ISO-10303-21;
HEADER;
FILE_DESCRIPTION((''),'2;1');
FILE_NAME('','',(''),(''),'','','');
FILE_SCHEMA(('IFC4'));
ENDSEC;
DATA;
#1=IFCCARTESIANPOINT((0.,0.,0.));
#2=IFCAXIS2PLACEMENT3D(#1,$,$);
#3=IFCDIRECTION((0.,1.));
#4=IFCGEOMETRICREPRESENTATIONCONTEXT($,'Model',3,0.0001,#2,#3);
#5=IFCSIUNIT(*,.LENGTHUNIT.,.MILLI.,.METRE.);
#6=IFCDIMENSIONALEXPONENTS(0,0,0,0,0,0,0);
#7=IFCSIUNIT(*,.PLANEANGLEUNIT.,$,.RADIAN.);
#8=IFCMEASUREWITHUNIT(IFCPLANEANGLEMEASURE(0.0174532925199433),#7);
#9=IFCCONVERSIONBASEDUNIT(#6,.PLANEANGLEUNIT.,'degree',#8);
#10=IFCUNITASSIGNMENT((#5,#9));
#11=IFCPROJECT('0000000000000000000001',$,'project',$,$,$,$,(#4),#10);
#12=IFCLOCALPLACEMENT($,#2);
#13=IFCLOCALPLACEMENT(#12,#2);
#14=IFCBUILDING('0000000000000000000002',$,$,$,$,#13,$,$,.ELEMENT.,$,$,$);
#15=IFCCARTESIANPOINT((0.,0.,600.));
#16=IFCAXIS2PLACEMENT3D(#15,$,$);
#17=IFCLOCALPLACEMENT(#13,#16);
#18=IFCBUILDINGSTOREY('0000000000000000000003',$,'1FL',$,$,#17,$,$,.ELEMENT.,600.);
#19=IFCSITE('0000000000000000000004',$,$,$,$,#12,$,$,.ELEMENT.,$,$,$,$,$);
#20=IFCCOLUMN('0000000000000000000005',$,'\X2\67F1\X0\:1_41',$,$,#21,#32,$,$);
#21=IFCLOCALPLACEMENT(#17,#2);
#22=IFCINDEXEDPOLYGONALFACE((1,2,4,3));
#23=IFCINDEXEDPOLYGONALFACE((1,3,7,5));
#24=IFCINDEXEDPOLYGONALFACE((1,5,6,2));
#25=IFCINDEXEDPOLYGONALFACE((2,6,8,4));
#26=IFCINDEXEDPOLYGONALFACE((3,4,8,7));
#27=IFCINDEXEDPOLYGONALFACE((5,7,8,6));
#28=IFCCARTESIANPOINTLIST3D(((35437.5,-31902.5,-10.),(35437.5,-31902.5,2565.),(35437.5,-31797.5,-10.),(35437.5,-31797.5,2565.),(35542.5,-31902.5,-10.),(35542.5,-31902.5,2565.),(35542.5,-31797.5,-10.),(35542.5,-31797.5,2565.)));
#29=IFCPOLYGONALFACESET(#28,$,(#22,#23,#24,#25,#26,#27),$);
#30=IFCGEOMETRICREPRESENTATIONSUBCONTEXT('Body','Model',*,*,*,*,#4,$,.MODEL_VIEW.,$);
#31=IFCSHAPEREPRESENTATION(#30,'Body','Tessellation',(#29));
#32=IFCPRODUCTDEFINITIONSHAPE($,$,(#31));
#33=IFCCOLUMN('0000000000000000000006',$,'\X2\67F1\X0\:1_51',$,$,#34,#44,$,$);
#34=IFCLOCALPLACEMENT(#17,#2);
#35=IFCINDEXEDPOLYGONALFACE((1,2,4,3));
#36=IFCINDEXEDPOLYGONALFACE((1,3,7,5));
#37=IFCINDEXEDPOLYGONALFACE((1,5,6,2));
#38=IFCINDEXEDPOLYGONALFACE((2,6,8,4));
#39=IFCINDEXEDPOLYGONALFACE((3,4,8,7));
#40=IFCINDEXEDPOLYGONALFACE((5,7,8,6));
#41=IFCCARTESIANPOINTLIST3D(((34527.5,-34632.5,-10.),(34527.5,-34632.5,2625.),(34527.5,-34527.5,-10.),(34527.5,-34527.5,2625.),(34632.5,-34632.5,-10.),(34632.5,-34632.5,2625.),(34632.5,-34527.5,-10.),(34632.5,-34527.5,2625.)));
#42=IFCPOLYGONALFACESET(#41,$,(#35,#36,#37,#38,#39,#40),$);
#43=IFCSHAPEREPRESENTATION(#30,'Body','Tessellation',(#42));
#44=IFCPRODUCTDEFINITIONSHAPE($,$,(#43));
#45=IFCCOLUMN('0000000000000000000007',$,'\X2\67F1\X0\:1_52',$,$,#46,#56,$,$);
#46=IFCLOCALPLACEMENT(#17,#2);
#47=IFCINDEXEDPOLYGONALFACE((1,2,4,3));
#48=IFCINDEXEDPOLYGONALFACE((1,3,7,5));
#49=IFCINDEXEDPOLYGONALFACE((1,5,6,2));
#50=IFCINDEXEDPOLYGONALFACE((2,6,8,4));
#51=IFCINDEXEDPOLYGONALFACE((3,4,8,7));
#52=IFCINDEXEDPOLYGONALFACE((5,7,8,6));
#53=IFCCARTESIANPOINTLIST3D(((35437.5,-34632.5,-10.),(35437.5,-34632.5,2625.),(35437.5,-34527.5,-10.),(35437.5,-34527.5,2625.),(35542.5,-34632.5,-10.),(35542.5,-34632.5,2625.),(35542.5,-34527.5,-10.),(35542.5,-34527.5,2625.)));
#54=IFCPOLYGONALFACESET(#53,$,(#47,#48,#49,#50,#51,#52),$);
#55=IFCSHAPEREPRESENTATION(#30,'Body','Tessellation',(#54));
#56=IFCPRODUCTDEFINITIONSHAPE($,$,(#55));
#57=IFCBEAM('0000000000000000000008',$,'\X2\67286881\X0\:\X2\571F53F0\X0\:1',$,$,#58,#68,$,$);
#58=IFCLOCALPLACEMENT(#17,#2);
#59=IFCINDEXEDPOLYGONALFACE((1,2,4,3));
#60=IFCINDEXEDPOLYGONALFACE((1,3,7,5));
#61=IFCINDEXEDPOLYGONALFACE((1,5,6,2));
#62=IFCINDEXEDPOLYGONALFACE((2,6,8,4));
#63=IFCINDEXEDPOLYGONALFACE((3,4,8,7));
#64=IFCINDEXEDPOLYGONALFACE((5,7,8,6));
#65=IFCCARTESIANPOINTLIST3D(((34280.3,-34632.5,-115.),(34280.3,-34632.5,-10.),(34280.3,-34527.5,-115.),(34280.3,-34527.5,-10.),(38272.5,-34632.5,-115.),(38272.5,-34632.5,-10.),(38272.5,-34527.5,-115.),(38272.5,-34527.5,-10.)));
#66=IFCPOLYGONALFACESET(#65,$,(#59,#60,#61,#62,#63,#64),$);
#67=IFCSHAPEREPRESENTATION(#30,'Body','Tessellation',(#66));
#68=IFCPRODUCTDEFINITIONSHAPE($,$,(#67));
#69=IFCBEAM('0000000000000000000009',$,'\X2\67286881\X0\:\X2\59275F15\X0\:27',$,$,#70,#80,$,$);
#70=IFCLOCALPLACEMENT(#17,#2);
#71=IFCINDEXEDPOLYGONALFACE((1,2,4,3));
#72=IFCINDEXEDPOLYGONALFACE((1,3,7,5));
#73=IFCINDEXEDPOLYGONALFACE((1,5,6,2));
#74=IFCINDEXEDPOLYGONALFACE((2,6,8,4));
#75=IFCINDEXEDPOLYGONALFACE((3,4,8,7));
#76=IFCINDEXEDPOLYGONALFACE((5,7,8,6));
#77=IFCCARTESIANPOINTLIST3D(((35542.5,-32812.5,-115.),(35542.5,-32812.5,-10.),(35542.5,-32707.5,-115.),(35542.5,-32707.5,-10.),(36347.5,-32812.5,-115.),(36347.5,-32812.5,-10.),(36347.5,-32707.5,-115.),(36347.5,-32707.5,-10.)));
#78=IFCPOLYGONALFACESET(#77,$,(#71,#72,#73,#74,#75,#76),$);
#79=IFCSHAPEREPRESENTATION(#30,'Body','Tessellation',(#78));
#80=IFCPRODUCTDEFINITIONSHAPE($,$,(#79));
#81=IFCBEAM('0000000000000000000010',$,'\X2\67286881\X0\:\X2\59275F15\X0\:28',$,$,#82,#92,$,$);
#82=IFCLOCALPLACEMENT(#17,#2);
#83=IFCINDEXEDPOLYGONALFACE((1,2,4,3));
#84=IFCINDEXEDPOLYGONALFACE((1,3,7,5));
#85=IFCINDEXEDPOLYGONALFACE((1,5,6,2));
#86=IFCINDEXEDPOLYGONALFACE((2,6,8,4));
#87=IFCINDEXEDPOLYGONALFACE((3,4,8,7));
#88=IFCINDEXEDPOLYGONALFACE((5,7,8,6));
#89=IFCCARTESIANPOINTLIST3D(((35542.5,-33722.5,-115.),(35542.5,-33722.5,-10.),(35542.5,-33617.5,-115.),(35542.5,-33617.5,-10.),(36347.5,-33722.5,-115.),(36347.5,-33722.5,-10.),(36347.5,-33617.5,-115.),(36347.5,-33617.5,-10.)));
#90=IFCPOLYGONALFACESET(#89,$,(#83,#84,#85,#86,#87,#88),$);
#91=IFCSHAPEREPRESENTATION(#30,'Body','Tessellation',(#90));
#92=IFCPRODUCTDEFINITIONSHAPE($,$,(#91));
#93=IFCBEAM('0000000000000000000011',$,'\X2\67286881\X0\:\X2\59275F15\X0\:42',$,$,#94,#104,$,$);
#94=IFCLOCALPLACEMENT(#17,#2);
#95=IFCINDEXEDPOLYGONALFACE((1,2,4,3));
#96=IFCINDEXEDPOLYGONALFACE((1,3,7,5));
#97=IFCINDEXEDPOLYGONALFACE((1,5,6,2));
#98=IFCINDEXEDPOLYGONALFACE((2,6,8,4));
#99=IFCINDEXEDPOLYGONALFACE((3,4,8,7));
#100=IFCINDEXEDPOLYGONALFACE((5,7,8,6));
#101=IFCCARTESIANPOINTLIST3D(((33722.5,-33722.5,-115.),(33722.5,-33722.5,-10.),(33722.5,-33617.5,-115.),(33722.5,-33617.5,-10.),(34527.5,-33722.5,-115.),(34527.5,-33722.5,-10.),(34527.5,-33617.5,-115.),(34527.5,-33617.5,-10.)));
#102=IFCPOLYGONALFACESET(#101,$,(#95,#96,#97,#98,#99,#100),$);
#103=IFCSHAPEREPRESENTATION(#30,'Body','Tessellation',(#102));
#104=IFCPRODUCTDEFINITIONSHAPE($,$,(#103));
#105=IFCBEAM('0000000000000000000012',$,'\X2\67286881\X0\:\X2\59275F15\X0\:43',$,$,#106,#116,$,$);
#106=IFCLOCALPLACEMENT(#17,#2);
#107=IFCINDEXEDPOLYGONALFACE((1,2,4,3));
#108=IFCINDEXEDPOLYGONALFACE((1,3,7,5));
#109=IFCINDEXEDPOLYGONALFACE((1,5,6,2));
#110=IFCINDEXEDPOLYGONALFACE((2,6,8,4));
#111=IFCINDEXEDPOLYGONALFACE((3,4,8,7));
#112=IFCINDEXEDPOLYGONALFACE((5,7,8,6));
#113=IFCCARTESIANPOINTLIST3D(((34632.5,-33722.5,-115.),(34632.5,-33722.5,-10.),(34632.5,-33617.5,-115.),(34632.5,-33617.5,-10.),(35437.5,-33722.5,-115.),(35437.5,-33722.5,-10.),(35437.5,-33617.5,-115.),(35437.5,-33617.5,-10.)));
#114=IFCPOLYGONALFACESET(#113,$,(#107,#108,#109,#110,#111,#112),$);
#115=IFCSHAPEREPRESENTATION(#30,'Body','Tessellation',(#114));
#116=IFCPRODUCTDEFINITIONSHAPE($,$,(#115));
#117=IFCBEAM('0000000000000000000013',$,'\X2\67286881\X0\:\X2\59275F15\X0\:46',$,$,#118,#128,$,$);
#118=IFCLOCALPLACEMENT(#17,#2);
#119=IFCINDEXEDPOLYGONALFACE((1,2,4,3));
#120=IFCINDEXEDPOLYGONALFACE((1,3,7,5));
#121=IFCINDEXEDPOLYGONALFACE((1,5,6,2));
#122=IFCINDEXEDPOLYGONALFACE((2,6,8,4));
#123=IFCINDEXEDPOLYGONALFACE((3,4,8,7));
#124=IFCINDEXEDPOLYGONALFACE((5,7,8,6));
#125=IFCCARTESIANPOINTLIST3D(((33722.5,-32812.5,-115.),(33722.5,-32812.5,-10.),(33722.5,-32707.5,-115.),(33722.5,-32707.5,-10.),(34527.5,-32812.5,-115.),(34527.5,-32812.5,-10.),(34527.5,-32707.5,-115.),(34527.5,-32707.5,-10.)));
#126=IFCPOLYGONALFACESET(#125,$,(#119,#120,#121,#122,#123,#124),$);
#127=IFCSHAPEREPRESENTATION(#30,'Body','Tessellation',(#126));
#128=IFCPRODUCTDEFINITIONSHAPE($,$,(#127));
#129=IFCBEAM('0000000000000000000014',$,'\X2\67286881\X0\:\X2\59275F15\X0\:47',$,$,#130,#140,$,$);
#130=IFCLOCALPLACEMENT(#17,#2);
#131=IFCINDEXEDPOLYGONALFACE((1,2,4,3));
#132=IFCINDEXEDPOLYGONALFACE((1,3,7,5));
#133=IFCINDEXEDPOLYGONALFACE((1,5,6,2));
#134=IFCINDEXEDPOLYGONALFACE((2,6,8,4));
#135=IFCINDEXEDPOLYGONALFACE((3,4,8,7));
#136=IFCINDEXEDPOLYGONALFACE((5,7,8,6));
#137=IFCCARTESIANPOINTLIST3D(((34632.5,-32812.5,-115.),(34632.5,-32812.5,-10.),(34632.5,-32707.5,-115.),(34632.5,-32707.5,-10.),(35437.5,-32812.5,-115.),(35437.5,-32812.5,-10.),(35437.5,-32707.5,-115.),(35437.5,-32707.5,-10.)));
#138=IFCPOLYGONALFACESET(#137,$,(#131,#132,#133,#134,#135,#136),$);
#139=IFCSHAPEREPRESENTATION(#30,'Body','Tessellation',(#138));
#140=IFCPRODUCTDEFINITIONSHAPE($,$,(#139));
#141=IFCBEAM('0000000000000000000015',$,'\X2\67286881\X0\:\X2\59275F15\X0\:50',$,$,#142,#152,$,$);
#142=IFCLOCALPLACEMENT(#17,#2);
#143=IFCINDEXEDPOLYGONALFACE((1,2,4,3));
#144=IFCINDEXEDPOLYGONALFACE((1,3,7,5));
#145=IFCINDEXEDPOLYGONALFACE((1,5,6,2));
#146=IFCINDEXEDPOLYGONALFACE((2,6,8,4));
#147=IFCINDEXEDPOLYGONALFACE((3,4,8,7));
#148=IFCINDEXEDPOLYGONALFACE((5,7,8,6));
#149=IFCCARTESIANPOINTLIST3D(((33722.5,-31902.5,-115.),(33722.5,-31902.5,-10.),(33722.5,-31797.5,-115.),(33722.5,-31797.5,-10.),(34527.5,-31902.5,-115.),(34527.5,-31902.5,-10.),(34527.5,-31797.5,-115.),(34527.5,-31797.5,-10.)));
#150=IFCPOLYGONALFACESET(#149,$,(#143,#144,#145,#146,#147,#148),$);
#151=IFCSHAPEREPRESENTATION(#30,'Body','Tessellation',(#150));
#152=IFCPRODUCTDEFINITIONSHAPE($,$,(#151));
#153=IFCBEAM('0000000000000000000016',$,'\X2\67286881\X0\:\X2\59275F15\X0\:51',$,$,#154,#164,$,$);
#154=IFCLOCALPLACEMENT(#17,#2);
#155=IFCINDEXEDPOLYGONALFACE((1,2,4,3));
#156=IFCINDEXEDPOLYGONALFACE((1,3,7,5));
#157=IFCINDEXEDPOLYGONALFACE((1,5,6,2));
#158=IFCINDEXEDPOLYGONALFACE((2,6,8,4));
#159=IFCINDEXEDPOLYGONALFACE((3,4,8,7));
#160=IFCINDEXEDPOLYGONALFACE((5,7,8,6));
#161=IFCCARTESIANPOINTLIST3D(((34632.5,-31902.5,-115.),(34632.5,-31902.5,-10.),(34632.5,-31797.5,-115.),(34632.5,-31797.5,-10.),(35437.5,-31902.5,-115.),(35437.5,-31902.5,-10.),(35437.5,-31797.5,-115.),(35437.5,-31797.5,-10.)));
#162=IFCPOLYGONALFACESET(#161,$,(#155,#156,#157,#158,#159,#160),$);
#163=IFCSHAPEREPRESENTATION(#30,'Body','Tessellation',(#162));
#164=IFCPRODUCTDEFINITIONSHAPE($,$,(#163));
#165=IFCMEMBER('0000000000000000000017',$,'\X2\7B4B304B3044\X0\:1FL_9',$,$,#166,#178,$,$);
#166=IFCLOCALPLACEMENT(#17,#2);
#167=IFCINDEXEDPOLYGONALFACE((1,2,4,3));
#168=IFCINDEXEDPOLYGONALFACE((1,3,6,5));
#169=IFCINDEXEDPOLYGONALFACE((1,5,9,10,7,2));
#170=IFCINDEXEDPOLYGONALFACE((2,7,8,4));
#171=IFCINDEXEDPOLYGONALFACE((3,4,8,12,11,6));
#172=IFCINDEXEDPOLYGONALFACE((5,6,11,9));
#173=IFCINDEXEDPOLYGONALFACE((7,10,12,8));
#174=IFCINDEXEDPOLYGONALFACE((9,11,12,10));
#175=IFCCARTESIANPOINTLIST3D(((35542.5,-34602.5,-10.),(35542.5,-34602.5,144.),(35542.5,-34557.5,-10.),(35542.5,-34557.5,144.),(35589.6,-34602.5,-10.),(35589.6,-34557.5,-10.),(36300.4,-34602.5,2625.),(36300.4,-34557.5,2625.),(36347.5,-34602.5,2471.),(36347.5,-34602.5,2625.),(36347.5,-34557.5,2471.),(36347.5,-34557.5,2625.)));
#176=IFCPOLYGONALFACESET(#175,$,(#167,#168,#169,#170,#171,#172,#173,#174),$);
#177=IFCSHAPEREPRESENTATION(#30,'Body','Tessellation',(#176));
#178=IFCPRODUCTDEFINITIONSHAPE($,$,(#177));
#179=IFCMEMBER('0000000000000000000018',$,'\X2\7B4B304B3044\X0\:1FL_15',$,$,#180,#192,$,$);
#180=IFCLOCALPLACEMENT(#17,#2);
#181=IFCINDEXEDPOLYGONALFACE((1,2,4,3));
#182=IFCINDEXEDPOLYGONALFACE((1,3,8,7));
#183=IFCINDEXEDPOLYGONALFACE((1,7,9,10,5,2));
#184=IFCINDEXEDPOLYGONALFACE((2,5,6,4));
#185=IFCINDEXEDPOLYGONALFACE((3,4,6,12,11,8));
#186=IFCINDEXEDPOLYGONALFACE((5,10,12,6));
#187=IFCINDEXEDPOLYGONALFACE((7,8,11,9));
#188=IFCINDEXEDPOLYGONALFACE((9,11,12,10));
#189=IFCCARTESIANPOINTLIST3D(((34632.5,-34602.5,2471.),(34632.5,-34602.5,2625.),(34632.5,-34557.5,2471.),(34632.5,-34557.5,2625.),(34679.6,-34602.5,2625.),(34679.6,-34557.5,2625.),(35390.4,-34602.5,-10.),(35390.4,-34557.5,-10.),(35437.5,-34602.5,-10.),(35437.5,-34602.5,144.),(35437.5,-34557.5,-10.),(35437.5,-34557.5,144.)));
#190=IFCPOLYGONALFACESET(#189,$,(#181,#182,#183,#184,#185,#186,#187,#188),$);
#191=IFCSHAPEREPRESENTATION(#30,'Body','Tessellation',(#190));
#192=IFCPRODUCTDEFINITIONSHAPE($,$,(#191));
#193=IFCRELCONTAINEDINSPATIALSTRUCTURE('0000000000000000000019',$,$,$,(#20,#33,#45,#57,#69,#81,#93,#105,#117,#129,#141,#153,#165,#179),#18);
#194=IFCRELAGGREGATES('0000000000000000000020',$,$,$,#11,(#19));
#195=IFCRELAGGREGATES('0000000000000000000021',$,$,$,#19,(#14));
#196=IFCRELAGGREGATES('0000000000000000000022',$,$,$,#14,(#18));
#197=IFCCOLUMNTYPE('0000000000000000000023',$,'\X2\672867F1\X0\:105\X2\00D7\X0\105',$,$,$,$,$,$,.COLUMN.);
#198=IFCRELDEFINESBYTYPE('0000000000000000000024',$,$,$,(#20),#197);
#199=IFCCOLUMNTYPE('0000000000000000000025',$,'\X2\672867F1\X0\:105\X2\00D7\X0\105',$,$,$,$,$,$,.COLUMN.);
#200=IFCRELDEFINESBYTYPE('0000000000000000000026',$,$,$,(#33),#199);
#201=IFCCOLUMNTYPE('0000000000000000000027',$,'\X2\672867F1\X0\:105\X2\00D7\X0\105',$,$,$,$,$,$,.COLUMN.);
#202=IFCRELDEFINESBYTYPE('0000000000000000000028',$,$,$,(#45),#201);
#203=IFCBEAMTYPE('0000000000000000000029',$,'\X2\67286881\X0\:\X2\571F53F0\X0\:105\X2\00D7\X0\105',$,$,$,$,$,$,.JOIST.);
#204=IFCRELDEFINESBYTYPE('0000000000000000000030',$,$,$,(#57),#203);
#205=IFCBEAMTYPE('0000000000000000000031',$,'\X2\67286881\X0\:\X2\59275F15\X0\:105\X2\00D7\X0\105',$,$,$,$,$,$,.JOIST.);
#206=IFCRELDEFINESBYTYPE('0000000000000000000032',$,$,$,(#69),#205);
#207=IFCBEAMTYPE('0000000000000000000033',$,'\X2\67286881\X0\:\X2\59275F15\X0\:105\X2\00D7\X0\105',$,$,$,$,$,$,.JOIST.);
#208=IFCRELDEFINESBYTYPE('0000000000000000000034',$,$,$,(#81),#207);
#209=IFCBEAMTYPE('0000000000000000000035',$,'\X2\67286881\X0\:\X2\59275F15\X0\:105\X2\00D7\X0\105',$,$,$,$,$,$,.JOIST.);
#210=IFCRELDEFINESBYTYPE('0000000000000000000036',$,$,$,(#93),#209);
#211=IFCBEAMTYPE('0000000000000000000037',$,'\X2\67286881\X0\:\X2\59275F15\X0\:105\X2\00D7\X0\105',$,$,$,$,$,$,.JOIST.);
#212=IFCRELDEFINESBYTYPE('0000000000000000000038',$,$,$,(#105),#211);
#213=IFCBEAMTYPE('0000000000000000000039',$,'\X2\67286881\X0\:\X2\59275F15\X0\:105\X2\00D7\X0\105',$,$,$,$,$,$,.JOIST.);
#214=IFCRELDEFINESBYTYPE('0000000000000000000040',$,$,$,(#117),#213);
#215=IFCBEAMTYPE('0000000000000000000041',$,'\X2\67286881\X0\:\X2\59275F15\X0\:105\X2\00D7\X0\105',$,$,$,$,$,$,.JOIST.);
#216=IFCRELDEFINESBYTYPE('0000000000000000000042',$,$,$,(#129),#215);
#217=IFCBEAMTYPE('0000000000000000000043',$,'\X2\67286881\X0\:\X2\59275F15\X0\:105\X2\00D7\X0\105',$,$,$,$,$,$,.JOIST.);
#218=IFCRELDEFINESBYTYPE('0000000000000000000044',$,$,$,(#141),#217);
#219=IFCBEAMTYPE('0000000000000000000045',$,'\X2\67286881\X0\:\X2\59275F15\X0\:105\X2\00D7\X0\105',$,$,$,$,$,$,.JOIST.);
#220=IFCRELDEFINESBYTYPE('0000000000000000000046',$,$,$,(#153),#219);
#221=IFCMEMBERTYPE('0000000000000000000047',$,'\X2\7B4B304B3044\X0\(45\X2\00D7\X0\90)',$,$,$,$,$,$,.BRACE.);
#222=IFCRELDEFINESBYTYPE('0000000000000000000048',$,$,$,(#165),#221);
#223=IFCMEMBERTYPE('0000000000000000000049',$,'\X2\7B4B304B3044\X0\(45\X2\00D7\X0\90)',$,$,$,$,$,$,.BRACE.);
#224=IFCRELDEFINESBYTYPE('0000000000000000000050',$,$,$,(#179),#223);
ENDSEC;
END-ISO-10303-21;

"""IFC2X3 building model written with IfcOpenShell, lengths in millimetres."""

from ifc_helpers import new_model, entity, si_unit, converted_unit, direction, frame, origin, origin_with_axes, origin_2d, place, context, subcontext, project, spatial, polyline, rectangle, outline, extrude, type_object, element, save


model = new_model("IFC2X3")

# Units and contexts
model_context = context("Model", 3, precision=0.0001, world=origin(), true_north=direction((0.0, 1.0)))
body_context = subcontext(model_context, "Body", "Model", "MODEL_VIEW")
ifc_project = project(units=[si_unit("LENGTHUNIT", "METRE", prefix="MILLI"), converted_unit("PLANEANGLEUNIT", "degree", entity("IfcPlaneAngleMeasure", 0.0174532925199433), si_unit("PLANEANGLEUNIT", "RADIAN"), dimensions=[0, 0, 0, 0, 0, 0, 0])], contexts=[model_context])

# Site, building, storey
site_placement = place(None, origin())
site = spatial("IfcSite", under=ifc_project, at=site_placement, CompositionType="ELEMENT")
building_placement = place(site_placement, origin())
building = spatial("IfcBuilding", under=site, at=building_placement, CompositionType="ELEMENT")
storey_placement = place(building_placement, frame((0.0, 0.0, 600.0)))
storey = spatial("IfcBuildingStorey", under=building, at=storey_placement, Name="1FL", CompositionType="ELEMENT", Elevation=600.0)

# Columns
column_type_1 = type_object("IfcColumnType", Name="木柱:105×105", PredefinedType="COLUMN")
column_1_placement = place(storey_placement, frame((35490.0, -31850.0, -10.0)))
element("IfcColumn", 1, at=column_1_placement, inside=storey, type_object=column_type_1, Name="柱:1_41", context=body_context, shape_type="SweptSolid", body=[
    extrude(rectangle(XDim=105.0, YDim=105.0, at=origin_2d()), origin_with_axes(), (0.0, 0.0, 1.0), 2575.0),
])
column_type_2 = type_object("IfcColumnType", Name="木柱:105×105", PredefinedType="COLUMN")
column_2_placement = place(storey_placement, frame((34580.0, -34580.0, -10.0)))
element("IfcColumn", 2, at=column_2_placement, inside=storey, type_object=column_type_2, Name="柱:1_51", context=body_context, shape_type="SweptSolid", body=[
    extrude(rectangle(XDim=105.0, YDim=105.0, at=origin_2d()), origin_with_axes(), (0.0, 0.0, 1.0), 2635.0),
])
column_type_3 = type_object("IfcColumnType", Name="木柱:105×105", PredefinedType="COLUMN")
column_3_placement = place(storey_placement, frame((35490.0, -34580.0, -10.0)))
element("IfcColumn", 3, at=column_3_placement, inside=storey, type_object=column_type_3, Name="柱:1_52", context=body_context, shape_type="SweptSolid", body=[
    extrude(rectangle(XDim=105.0, YDim=105.0, at=origin_2d()), origin_with_axes(), (0.0, 0.0, 1.0), 2635.0),
])

# Beams
beam_type_1 = type_object("IfcBeamType", Name="木梁:土台:105×105", PredefinedType="JOIST")
beam_1_placement = place(storey_placement, frame((34280.3, -34580.0, -62.5), z_axis=(1.0, 0.0, 0.0), x_axis=(0.0, 1.0, 0.0)))
element("IfcBeam", 4, at=beam_1_placement, inside=storey, type_object=beam_type_1, Name="木梁:土台:1", context=body_context, shape_type="SweptSolid", body=[
    extrude(rectangle(XDim=105.0, YDim=105.0, at=origin_2d()), origin_with_axes(), (0.0, 0.0, 1.0), 3992.2),
])
beam_type_2 = type_object("IfcBeamType", Name="木梁:大引:105×105", PredefinedType="JOIST")
beam_2_placement = place(storey_placement, frame((35542.5, -32760.0, -62.5), z_axis=(1.0, 0.0, 0.0), x_axis=(0.0, 1.0, 0.0)))
element("IfcBeam", 5, at=beam_2_placement, inside=storey, type_object=beam_type_2, Name="木梁:大引:27", context=body_context, shape_type="SweptSolid", body=[
    extrude(rectangle(XDim=105.0, YDim=105.0, at=origin_2d()), origin_with_axes(), (0.0, 0.0, 1.0), 805.0),
])
beam_type_3 = type_object("IfcBeamType", Name="木梁:大引:105×105", PredefinedType="JOIST")
beam_3_placement = place(storey_placement, frame((35542.5, -33670.0, -62.5), z_axis=(1.0, 0.0, 0.0), x_axis=(0.0, 1.0, 0.0)))
element("IfcBeam", 6, at=beam_3_placement, inside=storey, type_object=beam_type_3, Name="木梁:大引:28", context=body_context, shape_type="SweptSolid", body=[
    extrude(rectangle(XDim=105.0, YDim=105.0, at=origin_2d()), origin_with_axes(), (0.0, 0.0, 1.0), 805.0),
])
beam_type_4 = type_object("IfcBeamType", Name="木梁:大引:105×105", PredefinedType="JOIST")
beam_4_placement = place(storey_placement, frame((33722.5, -33670.0, -62.5), z_axis=(1.0, 0.0, 0.0), x_axis=(0.0, 1.0, 0.0)))
element("IfcBeam", 7, at=beam_4_placement, inside=storey, type_object=beam_type_4, Name="木梁:大引:42", context=body_context, shape_type="SweptSolid", body=[
    extrude(rectangle(XDim=105.0, YDim=105.0, at=origin_2d()), origin_with_axes(), (0.0, 0.0, 1.0), 805.0),
])
beam_type_5 = type_object("IfcBeamType", Name="木梁:大引:105×105", PredefinedType="JOIST")
beam_5_placement = place(storey_placement, frame((34632.5, -33670.0, -62.5), z_axis=(1.0, 0.0, 0.0), x_axis=(0.0, 1.0, 0.0)))
element("IfcBeam", 8, at=beam_5_placement, inside=storey, type_object=beam_type_5, Name="木梁:大引:43", context=body_context, shape_type="SweptSolid", body=[
    extrude(rectangle(XDim=105.0, YDim=105.0, at=origin_2d()), origin_with_axes(), (0.0, 0.0, 1.0), 805.0),
])
beam_type_6 = type_object("IfcBeamType", Name="木梁:大引:105×105", PredefinedType="JOIST")
beam_6_placement = place(storey_placement, frame((33722.5, -32760.0, -62.5), z_axis=(1.0, 0.0, 0.0), x_axis=(0.0, 1.0, 0.0)))
element("IfcBeam", 9, at=beam_6_placement, inside=storey, type_object=beam_type_6, Name="木梁:大引:46", context=body_context, shape_type="SweptSolid", body=[
    extrude(rectangle(XDim=105.0, YDim=105.0, at=origin_2d()), origin_with_axes(), (0.0, 0.0, 1.0), 805.0),
])
beam_type_7 = type_object("IfcBeamType", Name="木梁:大引:105×105", PredefinedType="JOIST")
beam_7_placement = place(storey_placement, frame((34632.5, -32760.0, -62.5), z_axis=(1.0, 0.0, 0.0), x_axis=(0.0, 1.0, 0.0)))
element("IfcBeam", 10, at=beam_7_placement, inside=storey, type_object=beam_type_7, Name="木梁:大引:47", context=body_context, shape_type="SweptSolid", body=[
    extrude(rectangle(XDim=105.0, YDim=105.0, at=origin_2d()), origin_with_axes(), (0.0, 0.0, 1.0), 805.0),
])
beam_type_8 = type_object("IfcBeamType", Name="木梁:大引:105×105", PredefinedType="JOIST")
beam_8_placement = place(storey_placement, frame((33722.5, -31850.0, -62.5), z_axis=(1.0, 0.0, 0.0), x_axis=(0.0, 1.0, 0.0)))
element("IfcBeam", 11, at=beam_8_placement, inside=storey, type_object=beam_type_8, Name="木梁:大引:50", context=body_context, shape_type="SweptSolid", body=[
    extrude(rectangle(XDim=105.0, YDim=105.0, at=origin_2d()), origin_with_axes(), (0.0, 0.0, 1.0), 805.0),
])
beam_type_9 = type_object("IfcBeamType", Name="木梁:大引:105×105", PredefinedType="JOIST")
beam_9_placement = place(storey_placement, frame((34632.5, -31850.0, -62.5), z_axis=(1.0, 0.0, 0.0), x_axis=(0.0, 1.0, 0.0)))
element("IfcBeam", 12, at=beam_9_placement, inside=storey, type_object=beam_type_9, Name="木梁:大引:51", context=body_context, shape_type="SweptSolid", body=[
    extrude(rectangle(XDim=105.0, YDim=105.0, at=origin_2d()), origin_with_axes(), (0.0, 0.0, 1.0), 805.0),
])

# Members
member_type_1 = type_object("IfcMemberType", Name="筋かい(45×90)", PredefinedType="BRACE")
member_1_placement = place(storey_placement, frame((35542.5, -34580.0, -10.0), z_axis=(0.292172, 0.0, 0.956366), x_axis=(-0.956366, 0.0, 0.292172)))
element("IfcMember", 13, at=member_1_placement, inside=storey, type_object=member_type_1, Name="筋かい:1FL_9", context=body_context, shape_type="SweptSolid", body=[
    extrude(outline(polyline([(0.0, 0.0), (13.7, -45.0), (2607.9, -45.0), (2755.2, 0.0), (2741.5, 45.0), (147.3, 45.0), (0.0, 0.0)])), frame((0.0, -22.5, 0.0), z_axis=(0.0, 1.0, 0.0), x_axis=(0.0, 0.0, 1.0)), (0.0, 0.0, 1.0), 45.0),
])
member_type_2 = type_object("IfcMemberType", Name="筋かい(45×90)", PredefinedType="BRACE")
member_2_placement = place(storey_placement, frame((35437.5, -34580.0, -10.0), z_axis=(-0.292172, 0.0, 0.956366), x_axis=(0.956366, 0.0, 0.292172)))
element("IfcMember", 14, at=member_2_placement, inside=storey, type_object=member_type_2, Name="筋かい:1FL_15", context=body_context, shape_type="SweptSolid", body=[
    extrude(outline(polyline([(0.0, 0.0), (13.7, -45.0), (2607.9, -45.0), (2755.2, 0.0), (2741.5, 45.0), (147.3, 45.0), (0.0, 0.0)])), frame((0.0, -22.5, 0.0), z_axis=(0.0, 1.0, 0.0), x_axis=(0.0, 0.0, 1.0)), (0.0, 0.0, 1.0), 45.0),
])

save(model, "model.ifc")
